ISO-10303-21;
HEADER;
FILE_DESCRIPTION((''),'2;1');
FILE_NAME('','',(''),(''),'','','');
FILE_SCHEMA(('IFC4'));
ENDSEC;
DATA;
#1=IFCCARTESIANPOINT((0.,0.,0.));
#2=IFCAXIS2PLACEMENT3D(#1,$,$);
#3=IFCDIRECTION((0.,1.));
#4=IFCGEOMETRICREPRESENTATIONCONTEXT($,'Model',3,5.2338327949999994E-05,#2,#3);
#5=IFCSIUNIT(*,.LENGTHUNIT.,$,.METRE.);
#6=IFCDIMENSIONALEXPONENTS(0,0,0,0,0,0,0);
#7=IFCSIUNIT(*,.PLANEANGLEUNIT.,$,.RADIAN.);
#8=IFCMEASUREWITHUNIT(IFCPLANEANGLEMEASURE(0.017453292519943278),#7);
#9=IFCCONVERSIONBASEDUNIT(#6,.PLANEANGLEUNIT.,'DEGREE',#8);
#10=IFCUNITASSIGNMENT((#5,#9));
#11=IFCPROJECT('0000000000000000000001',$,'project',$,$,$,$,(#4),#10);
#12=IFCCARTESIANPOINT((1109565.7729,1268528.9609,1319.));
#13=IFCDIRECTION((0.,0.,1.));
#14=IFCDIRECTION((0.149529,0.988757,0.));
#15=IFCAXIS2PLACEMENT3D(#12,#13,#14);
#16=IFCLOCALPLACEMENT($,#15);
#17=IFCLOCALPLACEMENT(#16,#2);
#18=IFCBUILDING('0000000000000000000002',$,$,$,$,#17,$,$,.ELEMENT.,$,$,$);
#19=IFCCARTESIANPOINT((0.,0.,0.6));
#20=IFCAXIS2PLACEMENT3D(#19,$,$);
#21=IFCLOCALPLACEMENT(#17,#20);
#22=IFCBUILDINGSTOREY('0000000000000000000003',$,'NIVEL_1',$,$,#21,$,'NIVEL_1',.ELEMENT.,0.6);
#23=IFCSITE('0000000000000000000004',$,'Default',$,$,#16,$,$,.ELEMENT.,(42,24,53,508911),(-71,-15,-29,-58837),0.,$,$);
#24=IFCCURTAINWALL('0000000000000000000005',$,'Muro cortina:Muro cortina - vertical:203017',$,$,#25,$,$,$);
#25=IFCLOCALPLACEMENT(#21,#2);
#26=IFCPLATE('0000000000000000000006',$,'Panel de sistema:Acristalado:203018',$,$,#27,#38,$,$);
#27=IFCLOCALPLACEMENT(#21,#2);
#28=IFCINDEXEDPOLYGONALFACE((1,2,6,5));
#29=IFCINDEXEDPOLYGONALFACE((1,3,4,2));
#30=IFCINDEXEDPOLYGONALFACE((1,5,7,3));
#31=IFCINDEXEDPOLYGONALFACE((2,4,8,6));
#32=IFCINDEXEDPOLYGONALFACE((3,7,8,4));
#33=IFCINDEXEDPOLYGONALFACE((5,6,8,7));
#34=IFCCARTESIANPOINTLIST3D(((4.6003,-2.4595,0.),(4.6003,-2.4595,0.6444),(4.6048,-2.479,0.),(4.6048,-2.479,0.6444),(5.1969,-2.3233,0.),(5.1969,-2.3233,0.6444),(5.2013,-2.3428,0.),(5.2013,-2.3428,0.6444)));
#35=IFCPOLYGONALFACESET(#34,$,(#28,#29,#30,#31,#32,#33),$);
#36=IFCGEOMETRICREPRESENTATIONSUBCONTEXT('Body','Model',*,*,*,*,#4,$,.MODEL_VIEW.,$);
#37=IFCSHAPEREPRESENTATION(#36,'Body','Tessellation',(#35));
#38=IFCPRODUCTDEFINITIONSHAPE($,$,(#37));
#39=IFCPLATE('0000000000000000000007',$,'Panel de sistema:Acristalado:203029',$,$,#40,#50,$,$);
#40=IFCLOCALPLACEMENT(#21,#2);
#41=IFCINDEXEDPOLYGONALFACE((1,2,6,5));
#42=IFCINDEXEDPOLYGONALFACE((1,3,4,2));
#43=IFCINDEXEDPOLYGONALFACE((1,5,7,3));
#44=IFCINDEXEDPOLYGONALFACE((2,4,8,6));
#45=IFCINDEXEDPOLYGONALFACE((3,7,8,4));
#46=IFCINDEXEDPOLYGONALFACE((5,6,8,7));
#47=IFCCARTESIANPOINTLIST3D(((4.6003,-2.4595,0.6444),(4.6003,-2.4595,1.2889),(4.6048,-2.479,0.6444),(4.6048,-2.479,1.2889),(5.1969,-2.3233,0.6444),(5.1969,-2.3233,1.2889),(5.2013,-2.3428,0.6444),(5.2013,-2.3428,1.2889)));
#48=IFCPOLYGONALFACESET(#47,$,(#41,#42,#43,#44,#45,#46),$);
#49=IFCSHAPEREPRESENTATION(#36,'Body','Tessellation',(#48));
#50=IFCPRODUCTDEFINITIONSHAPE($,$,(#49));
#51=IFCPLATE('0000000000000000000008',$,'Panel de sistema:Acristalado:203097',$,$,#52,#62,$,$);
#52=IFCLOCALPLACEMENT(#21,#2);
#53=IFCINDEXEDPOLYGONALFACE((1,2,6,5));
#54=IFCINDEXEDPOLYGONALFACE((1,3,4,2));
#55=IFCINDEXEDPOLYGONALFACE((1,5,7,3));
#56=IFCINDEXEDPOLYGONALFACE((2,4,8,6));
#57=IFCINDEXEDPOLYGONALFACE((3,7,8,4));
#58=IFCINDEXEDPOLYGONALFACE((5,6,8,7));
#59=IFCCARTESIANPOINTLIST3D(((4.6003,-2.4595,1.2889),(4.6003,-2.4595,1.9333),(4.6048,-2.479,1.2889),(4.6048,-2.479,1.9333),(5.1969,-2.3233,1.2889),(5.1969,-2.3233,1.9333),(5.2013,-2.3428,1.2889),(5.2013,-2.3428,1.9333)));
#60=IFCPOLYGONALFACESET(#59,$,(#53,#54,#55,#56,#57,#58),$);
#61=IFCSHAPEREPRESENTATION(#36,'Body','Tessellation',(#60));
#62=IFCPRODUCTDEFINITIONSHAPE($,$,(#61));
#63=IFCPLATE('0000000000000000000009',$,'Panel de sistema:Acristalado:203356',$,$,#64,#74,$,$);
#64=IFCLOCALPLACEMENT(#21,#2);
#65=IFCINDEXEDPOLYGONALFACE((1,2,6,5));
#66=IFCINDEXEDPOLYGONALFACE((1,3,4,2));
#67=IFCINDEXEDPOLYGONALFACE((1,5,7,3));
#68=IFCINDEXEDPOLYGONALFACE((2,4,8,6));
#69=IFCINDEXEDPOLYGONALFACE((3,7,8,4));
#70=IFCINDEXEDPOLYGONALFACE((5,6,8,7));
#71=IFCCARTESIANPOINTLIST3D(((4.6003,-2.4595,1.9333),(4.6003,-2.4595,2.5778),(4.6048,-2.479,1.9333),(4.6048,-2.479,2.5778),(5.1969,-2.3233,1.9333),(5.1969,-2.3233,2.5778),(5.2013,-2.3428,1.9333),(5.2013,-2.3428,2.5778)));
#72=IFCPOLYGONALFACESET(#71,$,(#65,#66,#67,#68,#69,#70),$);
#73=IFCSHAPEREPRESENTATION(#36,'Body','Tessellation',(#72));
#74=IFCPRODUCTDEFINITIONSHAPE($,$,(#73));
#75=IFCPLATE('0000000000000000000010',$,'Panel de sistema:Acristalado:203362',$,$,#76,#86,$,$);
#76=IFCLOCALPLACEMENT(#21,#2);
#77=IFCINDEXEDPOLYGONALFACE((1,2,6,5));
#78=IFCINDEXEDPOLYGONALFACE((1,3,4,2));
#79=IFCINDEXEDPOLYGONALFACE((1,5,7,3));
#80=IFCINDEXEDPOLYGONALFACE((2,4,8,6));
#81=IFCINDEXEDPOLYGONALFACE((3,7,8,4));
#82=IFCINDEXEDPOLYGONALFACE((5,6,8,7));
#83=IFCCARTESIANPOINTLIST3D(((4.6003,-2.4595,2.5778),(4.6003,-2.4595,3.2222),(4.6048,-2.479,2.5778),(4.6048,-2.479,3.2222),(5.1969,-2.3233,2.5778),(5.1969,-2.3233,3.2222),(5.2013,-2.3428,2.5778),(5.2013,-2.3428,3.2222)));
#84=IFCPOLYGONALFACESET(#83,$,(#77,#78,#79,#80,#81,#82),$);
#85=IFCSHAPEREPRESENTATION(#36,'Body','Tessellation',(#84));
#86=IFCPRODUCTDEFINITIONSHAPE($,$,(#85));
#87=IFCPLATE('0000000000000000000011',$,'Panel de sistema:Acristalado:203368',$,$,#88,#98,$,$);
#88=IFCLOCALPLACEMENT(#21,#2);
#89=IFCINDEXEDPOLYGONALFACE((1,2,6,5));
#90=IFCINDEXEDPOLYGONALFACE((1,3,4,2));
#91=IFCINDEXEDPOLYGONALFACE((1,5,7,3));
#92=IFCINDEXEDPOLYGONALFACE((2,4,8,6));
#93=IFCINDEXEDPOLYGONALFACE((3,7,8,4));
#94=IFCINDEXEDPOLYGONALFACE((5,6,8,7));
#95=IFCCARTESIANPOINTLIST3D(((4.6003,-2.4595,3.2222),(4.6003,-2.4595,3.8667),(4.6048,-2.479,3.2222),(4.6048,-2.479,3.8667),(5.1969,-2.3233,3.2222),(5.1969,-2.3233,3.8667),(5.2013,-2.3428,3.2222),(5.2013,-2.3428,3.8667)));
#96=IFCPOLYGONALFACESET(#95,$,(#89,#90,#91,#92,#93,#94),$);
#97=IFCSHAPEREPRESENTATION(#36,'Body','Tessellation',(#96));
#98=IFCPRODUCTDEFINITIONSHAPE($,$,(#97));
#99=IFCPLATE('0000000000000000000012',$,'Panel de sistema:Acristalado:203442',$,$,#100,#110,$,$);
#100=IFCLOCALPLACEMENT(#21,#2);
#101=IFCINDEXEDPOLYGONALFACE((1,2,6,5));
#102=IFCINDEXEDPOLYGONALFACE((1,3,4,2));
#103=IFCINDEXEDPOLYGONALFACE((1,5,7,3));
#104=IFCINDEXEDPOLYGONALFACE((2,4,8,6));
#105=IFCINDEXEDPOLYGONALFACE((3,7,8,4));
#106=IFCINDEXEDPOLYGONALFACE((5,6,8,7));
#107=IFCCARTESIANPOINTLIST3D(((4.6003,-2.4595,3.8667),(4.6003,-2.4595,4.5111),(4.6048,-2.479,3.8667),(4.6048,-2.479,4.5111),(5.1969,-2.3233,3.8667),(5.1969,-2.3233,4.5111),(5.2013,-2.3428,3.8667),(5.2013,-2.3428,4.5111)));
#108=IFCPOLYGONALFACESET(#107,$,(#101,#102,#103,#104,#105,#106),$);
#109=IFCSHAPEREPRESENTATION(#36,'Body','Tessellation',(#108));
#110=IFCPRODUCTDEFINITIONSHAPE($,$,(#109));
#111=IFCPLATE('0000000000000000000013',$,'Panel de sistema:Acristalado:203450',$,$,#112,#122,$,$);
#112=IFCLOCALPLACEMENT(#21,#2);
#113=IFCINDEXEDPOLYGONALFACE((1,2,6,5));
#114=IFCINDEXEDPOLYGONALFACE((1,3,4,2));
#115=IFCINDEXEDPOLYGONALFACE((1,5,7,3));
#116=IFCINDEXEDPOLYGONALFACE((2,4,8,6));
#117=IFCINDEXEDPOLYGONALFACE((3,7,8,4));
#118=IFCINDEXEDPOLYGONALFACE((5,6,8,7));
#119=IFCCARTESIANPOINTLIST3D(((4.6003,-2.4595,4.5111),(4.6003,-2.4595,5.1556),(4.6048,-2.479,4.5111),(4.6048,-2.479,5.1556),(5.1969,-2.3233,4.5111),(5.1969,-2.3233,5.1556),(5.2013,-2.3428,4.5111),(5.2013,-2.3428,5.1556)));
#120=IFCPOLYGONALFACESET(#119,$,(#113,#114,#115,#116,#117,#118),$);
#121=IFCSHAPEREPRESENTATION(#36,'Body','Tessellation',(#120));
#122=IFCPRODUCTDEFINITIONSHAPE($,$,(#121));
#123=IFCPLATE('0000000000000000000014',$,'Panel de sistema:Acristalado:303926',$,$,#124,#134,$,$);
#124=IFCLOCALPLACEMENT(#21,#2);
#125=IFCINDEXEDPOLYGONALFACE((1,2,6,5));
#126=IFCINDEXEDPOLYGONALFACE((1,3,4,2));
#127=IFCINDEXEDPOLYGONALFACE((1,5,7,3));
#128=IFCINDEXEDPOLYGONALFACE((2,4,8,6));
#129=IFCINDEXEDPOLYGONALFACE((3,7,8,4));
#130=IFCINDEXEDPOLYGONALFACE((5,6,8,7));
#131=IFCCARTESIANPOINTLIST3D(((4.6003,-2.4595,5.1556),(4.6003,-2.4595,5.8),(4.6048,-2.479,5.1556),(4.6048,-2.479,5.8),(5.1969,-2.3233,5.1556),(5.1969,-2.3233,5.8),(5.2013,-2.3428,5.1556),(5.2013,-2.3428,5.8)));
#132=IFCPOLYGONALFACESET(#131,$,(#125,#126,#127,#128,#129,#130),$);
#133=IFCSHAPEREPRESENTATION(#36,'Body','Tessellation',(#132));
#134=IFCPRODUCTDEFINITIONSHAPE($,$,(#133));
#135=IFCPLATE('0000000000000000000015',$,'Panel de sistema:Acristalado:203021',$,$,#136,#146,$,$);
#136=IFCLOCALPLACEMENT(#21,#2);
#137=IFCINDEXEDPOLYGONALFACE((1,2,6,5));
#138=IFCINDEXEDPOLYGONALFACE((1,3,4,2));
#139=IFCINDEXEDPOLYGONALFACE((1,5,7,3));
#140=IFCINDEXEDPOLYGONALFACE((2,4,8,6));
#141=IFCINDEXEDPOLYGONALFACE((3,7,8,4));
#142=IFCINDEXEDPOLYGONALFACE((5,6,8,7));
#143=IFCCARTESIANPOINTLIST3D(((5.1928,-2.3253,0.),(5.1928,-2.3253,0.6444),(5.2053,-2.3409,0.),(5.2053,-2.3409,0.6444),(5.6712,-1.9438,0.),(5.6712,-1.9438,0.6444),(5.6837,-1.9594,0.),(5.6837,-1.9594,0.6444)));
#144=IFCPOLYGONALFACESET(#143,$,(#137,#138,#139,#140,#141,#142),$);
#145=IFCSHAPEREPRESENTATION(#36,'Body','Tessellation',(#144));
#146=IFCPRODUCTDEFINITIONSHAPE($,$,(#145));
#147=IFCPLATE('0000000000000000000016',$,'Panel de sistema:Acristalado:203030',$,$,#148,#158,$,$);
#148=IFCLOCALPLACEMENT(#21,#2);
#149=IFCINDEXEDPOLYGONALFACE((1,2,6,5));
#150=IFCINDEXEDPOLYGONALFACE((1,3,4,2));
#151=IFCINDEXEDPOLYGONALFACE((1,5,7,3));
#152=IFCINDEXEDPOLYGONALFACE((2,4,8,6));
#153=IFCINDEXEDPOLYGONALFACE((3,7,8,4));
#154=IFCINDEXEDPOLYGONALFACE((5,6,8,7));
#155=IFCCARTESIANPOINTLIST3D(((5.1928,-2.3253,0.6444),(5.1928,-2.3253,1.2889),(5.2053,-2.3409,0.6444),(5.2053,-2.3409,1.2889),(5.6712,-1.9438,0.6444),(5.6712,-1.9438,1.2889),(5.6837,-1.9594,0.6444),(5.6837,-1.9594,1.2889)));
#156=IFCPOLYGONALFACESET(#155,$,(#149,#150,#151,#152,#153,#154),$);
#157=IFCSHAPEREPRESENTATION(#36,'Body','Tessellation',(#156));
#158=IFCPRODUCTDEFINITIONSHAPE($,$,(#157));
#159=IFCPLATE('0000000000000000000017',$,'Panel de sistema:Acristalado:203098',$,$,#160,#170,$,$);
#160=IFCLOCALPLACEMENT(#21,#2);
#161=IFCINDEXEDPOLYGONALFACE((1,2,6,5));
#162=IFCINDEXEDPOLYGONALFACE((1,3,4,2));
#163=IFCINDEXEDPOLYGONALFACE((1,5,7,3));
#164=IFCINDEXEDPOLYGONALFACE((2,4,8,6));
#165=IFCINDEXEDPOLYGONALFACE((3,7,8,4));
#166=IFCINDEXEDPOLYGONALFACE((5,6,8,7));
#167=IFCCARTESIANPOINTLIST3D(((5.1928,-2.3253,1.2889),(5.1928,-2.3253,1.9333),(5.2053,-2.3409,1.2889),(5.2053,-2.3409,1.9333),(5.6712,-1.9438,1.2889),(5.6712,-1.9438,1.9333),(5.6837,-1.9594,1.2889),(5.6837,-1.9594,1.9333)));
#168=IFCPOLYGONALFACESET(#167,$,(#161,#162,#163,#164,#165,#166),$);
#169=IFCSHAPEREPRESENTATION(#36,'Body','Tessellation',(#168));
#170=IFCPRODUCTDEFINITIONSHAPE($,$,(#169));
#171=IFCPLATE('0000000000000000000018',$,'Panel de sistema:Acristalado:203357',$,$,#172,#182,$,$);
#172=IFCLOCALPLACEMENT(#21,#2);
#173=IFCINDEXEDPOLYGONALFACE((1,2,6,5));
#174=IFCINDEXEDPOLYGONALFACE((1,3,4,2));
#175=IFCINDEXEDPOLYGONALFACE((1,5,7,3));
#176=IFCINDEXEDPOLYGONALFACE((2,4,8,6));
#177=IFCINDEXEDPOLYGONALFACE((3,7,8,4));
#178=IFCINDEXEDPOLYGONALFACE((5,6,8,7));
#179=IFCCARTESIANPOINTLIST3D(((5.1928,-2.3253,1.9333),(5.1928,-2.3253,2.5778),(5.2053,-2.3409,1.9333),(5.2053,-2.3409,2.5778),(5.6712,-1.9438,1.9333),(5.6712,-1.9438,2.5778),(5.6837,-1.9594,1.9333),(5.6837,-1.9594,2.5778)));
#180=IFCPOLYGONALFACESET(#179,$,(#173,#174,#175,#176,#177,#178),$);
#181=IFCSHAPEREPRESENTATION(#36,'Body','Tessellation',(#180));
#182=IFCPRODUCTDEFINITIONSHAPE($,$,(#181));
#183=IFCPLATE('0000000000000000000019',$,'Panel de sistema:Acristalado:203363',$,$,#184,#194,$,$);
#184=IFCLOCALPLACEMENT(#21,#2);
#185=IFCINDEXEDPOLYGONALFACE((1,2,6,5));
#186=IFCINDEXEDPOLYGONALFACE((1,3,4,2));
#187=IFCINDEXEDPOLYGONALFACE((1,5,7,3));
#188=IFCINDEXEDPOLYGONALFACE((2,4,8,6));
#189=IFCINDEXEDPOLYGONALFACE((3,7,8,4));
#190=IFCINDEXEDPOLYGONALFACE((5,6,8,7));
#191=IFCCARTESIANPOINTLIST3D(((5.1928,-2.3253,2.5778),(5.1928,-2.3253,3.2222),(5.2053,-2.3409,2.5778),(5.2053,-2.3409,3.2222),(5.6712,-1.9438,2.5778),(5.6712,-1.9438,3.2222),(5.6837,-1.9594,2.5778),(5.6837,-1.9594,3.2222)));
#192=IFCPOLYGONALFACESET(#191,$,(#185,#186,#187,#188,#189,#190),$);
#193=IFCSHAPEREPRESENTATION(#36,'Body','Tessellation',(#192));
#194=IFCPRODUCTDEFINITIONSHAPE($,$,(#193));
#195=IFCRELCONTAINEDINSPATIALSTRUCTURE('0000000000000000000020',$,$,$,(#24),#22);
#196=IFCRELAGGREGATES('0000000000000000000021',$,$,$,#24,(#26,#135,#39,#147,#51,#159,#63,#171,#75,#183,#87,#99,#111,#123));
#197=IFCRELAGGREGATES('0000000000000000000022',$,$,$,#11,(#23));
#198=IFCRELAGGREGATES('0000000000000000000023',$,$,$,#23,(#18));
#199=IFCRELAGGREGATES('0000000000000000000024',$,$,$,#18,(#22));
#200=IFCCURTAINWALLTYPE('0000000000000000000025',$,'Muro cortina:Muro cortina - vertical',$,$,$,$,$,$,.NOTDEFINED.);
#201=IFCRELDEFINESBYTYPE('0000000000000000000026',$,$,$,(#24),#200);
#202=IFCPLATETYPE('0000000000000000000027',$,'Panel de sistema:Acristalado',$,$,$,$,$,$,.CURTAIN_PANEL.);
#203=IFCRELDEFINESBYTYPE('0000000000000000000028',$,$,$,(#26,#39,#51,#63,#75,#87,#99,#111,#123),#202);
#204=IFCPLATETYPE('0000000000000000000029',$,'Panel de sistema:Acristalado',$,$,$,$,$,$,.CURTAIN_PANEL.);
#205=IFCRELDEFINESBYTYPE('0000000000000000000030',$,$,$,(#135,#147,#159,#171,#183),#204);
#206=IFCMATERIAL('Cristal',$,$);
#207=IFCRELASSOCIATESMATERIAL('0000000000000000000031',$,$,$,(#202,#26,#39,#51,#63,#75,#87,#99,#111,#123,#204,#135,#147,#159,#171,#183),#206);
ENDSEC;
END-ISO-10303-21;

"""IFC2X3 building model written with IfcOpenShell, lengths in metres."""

from ifc_helpers import new_model, entity, si_unit, converted_unit, direction, frame, frame_2d, origin, place, context, subcontext, project, spatial, rectangle, extrude, source, transform, mapped, material, type_object, type_shapes, element, aggregate, save


model = new_model("IFC2X3")

# Units and contexts
model_context = context("Model", 3, precision=5.2338327949999994e-05, world=origin(), true_north=direction((0.0, 1.0)))
body_context = subcontext(model_context, "Body", "Model", "MODEL_VIEW")
ifc_project = project(units=[si_unit("LENGTHUNIT", "METRE"), converted_unit("PLANEANGLEUNIT", "DEGREE", entity("IfcPlaneAngleMeasure", 0.017453292519943278), si_unit("PLANEANGLEUNIT", "RADIAN"), dimensions=[0, 0, 0, 0, 0, 0, 0])], contexts=[model_context])

# Site, building, storey
site_placement = place(None, frame((1109565.7729, 1268528.9609, 1319.0), z_axis=(0.0, 0.0, 1.0), x_axis=(0.149529, 0.988757, 0.0)))
site = spatial("IfcSite", under=ifc_project, at=site_placement, Name="Default", CompositionType="ELEMENT", RefLatitude=(42, 24, 53, 508911), RefLongitude=(-71, -15, -29, -58837), RefElevation=0.0)
building_placement = place(site_placement, origin())
building = spatial("IfcBuilding", under=site, at=building_placement, CompositionType="ELEMENT")
storey_placement = place(building_placement, frame((0.0, 0.0, 0.6)))
storey = spatial("IfcBuildingStorey", under=building, at=storey_placement, Name="NIVEL_1", LongName="NIVEL_1", CompositionType="ELEMENT", Elevation=0.6)

# Curtain wall, plates
curtain_wall_type = type_object("IfcCurtainWallType", Name="Muro cortina:Muro cortina - vertical", PredefinedType="NOTDEFINED")
curtain_wall_1_placement = place(storey_placement, frame((0.0, 0.0, -0.6)))
curtain_wall_1 = element("IfcCurtainWall", 1, at=curtain_wall_1_placement, inside=storey, type_object=curtain_wall_type, Name="Muro cortina:Muro cortina - vertical:203017")
ifc_material_1 = material(Name="Cristal")
plate_type_1 = type_object("IfcPlateType", Name="Panel de sistema:Acristalado", PredefinedType="CURTAIN_PANEL", material=ifc_material_1)
shared_shape_1 = source(origin(), body_context, "Body", "SweptSolid", [
    extrude(rectangle(XDim=0.02, YDim=0.6119, at=frame_2d((0.0, 0.0), x_axis=(1.0, 0.0))), frame((0.0, 0.0, 0.0), z_axis=(0.0, 0.0, 1.0), x_axis=(0.0, 1.0, 0.0)), (0.0, 0.0, 1.0), 0.6444),
])
type_shapes(plate_type_1, [shared_shape_1])
plate_1_placement = place(curtain_wall_1_placement, frame((4.9008, -2.4012, 0.6), z_axis=(0.0, 0.0, 1.0), x_axis=(0.974928, 0.222521, 0.0)))
plate_1 = element("IfcPlate", 2, at=plate_1_placement, type_object=plate_type_1, material=ifc_material_1, Name="Panel de sistema:Acristalado:203018", context=body_context, shape_type="MappedRepresentation", body=[
    mapped(shared_shape_1, transform((0.0, 0.0, 0.0), scale=1.0)),
])
plate_2_placement = place(curtain_wall_1_placement, frame((4.9008, -2.4012, 1.2444), z_axis=(0.0, 0.0, 1.0), x_axis=(0.974928, 0.222521, 0.0)))
plate_2 = element("IfcPlate", 3, at=plate_2_placement, type_object=plate_type_1, material=ifc_material_1, Name="Panel de sistema:Acristalado:203029", context=body_context, shape_type="MappedRepresentation", body=[
    mapped(shared_shape_1, transform((0.0, 0.0, 0.0), scale=1.0)),
])
plate_3_placement = place(curtain_wall_1_placement, frame((4.9008, -2.4012, 1.8889), z_axis=(0.0, 0.0, 1.0), x_axis=(0.974928, 0.222521, 0.0)))
plate_3 = element("IfcPlate", 4, at=plate_3_placement, type_object=plate_type_1, material=ifc_material_1, Name="Panel de sistema:Acristalado:203097", context=body_context, shape_type="MappedRepresentation", body=[
    mapped(shared_shape_1, transform((0.0, 0.0, 0.0), scale=1.0)),
])
plate_4_placement = place(curtain_wall_1_placement, frame((4.9008, -2.4012, 2.5333), z_axis=(0.0, 0.0, 1.0), x_axis=(0.974928, 0.222521, 0.0)))
plate_4 = element("IfcPlate", 5, at=plate_4_placement, type_object=plate_type_1, material=ifc_material_1, Name="Panel de sistema:Acristalado:203356", context=body_context, shape_type="MappedRepresentation", body=[
    mapped(shared_shape_1, transform((0.0, 0.0, 0.0), scale=1.0)),
])
plate_5_placement = place(curtain_wall_1_placement, frame((4.9008, -2.4012, 3.1778), z_axis=(0.0, 0.0, 1.0), x_axis=(0.974928, 0.222521, 0.0)))
plate_5 = element("IfcPlate", 6, at=plate_5_placement, type_object=plate_type_1, material=ifc_material_1, Name="Panel de sistema:Acristalado:203362", context=body_context, shape_type="MappedRepresentation", body=[
    mapped(shared_shape_1, transform((0.0, 0.0, 0.0), scale=1.0)),
])
plate_6_placement = place(curtain_wall_1_placement, frame((4.9008, -2.4012, 3.8222), z_axis=(0.0, 0.0, 1.0), x_axis=(0.974928, 0.222521, 0.0)))
plate_6 = element("IfcPlate", 7, at=plate_6_placement, type_object=plate_type_1, material=ifc_material_1, Name="Panel de sistema:Acristalado:203368", context=body_context, shape_type="MappedRepresentation", body=[
    mapped(shared_shape_1, transform((0.0, 0.0, 0.0), scale=1.0)),
])
plate_7_placement = place(curtain_wall_1_placement, frame((4.9008, -2.4012, 4.4667), z_axis=(0.0, 0.0, 1.0), x_axis=(0.974928, 0.222521, 0.0)))
plate_7 = element("IfcPlate", 8, at=plate_7_placement, type_object=plate_type_1, material=ifc_material_1, Name="Panel de sistema:Acristalado:203442", context=body_context, shape_type="MappedRepresentation", body=[
    mapped(shared_shape_1, transform((0.0, 0.0, 0.0), scale=1.0)),
])
plate_8_placement = place(curtain_wall_1_placement, frame((4.9008, -2.4012, 5.1111), z_axis=(0.0, 0.0, 1.0), x_axis=(0.974928, 0.222521, 0.0)))
plate_8 = element("IfcPlate", 9, at=plate_8_placement, type_object=plate_type_1, material=ifc_material_1, Name="Panel de sistema:Acristalado:203450", context=body_context, shape_type="MappedRepresentation", body=[
    mapped(shared_shape_1, transform((0.0, 0.0, 0.0), scale=1.0)),
])
plate_9_placement = place(curtain_wall_1_placement, frame((4.9008, -2.4012, 5.7556), z_axis=(0.0, 0.0, 1.0), x_axis=(0.974928, 0.222521, 0.0)))
plate_9 = element("IfcPlate", 10, at=plate_9_placement, type_object=plate_type_1, material=ifc_material_1, Name="Panel de sistema:Acristalado:303926", context=body_context, shape_type="MappedRepresentation", body=[
    mapped(shared_shape_1, transform((0.0, 0.0, 0.0), scale=1.0)),
])
plate_type_2 = type_object("IfcPlateType", Name="Panel de sistema:Acristalado", PredefinedType="CURTAIN_PANEL", material=ifc_material_1)
shared_shape_2 = source(origin(), body_context, "Body", "SweptSolid", [
    extrude(rectangle(XDim=0.02, YDim=0.6119, at=frame_2d((0.0, 0.0), x_axis=(1.0, 0.0))), frame((0.0, 0.0, 0.0), z_axis=(0.0, 0.0, 1.0), x_axis=(0.0, 1.0, 0.0)), (0.0, 0.0, 1.0), 0.6444),
])
type_shapes(plate_type_2, [shared_shape_2])
plate_10_placement = place(curtain_wall_1_placement, frame((5.4383, -2.1423, 0.6), z_axis=(0.0, 0.0, 1.0), x_axis=(0.781832, 0.62349, 0.0)))
plate_10 = element("IfcPlate", 11, at=plate_10_placement, type_object=plate_type_2, material=ifc_material_1, Name="Panel de sistema:Acristalado:203021", context=body_context, shape_type="MappedRepresentation", body=[
    mapped(shared_shape_2, transform((0.0, 0.0, 0.0), scale=1.0)),
])
plate_11_placement = place(curtain_wall_1_placement, frame((5.4383, -2.1423, 1.2444), z_axis=(0.0, 0.0, 1.0), x_axis=(0.781832, 0.62349, 0.0)))
plate_11 = element("IfcPlate", 12, at=plate_11_placement, type_object=plate_type_2, material=ifc_material_1, Name="Panel de sistema:Acristalado:203030", context=body_context, shape_type="MappedRepresentation", body=[
    mapped(shared_shape_2, transform((0.0, 0.0, 0.0), scale=1.0)),
])
plate_12_placement = place(curtain_wall_1_placement, frame((5.4383, -2.1423, 1.8889), z_axis=(0.0, 0.0, 1.0), x_axis=(0.781832, 0.62349, 0.0)))
plate_12 = element("IfcPlate", 13, at=plate_12_placement, type_object=plate_type_2, material=ifc_material_1, Name="Panel de sistema:Acristalado:203098", context=body_context, shape_type="MappedRepresentation", body=[
    mapped(shared_shape_2, transform((0.0, 0.0, 0.0), scale=1.0)),
])
plate_13_placement = place(curtain_wall_1_placement, frame((5.4383, -2.1423, 2.5333), z_axis=(0.0, 0.0, 1.0), x_axis=(0.781832, 0.62349, 0.0)))
plate_13 = element("IfcPlate", 14, at=plate_13_placement, type_object=plate_type_2, material=ifc_material_1, Name="Panel de sistema:Acristalado:203357", context=body_context, shape_type="MappedRepresentation", body=[
    mapped(shared_shape_2, transform((0.0, 0.0, 0.0), scale=1.0)),
])
plate_14_placement = place(curtain_wall_1_placement, frame((5.4383, -2.1423, 3.1778), z_axis=(0.0, 0.0, 1.0), x_axis=(0.781832, 0.62349, 0.0)))
plate_14 = element("IfcPlate", 15, at=plate_14_placement, type_object=plate_type_2, material=ifc_material_1, Name="Panel de sistema:Acristalado:203363", context=body_context, shape_type="MappedRepresentation", body=[
    mapped(shared_shape_2, transform((0.0, 0.0, 0.0), scale=1.0)),
])
aggregate(curtain_wall_1, [plate_1, plate_10, plate_2, plate_11, plate_3, plate_12, plate_4, plate_13, plate_5, plate_14, plate_6, plate_7, plate_8, plate_9])

save(model, "model.ifc")
